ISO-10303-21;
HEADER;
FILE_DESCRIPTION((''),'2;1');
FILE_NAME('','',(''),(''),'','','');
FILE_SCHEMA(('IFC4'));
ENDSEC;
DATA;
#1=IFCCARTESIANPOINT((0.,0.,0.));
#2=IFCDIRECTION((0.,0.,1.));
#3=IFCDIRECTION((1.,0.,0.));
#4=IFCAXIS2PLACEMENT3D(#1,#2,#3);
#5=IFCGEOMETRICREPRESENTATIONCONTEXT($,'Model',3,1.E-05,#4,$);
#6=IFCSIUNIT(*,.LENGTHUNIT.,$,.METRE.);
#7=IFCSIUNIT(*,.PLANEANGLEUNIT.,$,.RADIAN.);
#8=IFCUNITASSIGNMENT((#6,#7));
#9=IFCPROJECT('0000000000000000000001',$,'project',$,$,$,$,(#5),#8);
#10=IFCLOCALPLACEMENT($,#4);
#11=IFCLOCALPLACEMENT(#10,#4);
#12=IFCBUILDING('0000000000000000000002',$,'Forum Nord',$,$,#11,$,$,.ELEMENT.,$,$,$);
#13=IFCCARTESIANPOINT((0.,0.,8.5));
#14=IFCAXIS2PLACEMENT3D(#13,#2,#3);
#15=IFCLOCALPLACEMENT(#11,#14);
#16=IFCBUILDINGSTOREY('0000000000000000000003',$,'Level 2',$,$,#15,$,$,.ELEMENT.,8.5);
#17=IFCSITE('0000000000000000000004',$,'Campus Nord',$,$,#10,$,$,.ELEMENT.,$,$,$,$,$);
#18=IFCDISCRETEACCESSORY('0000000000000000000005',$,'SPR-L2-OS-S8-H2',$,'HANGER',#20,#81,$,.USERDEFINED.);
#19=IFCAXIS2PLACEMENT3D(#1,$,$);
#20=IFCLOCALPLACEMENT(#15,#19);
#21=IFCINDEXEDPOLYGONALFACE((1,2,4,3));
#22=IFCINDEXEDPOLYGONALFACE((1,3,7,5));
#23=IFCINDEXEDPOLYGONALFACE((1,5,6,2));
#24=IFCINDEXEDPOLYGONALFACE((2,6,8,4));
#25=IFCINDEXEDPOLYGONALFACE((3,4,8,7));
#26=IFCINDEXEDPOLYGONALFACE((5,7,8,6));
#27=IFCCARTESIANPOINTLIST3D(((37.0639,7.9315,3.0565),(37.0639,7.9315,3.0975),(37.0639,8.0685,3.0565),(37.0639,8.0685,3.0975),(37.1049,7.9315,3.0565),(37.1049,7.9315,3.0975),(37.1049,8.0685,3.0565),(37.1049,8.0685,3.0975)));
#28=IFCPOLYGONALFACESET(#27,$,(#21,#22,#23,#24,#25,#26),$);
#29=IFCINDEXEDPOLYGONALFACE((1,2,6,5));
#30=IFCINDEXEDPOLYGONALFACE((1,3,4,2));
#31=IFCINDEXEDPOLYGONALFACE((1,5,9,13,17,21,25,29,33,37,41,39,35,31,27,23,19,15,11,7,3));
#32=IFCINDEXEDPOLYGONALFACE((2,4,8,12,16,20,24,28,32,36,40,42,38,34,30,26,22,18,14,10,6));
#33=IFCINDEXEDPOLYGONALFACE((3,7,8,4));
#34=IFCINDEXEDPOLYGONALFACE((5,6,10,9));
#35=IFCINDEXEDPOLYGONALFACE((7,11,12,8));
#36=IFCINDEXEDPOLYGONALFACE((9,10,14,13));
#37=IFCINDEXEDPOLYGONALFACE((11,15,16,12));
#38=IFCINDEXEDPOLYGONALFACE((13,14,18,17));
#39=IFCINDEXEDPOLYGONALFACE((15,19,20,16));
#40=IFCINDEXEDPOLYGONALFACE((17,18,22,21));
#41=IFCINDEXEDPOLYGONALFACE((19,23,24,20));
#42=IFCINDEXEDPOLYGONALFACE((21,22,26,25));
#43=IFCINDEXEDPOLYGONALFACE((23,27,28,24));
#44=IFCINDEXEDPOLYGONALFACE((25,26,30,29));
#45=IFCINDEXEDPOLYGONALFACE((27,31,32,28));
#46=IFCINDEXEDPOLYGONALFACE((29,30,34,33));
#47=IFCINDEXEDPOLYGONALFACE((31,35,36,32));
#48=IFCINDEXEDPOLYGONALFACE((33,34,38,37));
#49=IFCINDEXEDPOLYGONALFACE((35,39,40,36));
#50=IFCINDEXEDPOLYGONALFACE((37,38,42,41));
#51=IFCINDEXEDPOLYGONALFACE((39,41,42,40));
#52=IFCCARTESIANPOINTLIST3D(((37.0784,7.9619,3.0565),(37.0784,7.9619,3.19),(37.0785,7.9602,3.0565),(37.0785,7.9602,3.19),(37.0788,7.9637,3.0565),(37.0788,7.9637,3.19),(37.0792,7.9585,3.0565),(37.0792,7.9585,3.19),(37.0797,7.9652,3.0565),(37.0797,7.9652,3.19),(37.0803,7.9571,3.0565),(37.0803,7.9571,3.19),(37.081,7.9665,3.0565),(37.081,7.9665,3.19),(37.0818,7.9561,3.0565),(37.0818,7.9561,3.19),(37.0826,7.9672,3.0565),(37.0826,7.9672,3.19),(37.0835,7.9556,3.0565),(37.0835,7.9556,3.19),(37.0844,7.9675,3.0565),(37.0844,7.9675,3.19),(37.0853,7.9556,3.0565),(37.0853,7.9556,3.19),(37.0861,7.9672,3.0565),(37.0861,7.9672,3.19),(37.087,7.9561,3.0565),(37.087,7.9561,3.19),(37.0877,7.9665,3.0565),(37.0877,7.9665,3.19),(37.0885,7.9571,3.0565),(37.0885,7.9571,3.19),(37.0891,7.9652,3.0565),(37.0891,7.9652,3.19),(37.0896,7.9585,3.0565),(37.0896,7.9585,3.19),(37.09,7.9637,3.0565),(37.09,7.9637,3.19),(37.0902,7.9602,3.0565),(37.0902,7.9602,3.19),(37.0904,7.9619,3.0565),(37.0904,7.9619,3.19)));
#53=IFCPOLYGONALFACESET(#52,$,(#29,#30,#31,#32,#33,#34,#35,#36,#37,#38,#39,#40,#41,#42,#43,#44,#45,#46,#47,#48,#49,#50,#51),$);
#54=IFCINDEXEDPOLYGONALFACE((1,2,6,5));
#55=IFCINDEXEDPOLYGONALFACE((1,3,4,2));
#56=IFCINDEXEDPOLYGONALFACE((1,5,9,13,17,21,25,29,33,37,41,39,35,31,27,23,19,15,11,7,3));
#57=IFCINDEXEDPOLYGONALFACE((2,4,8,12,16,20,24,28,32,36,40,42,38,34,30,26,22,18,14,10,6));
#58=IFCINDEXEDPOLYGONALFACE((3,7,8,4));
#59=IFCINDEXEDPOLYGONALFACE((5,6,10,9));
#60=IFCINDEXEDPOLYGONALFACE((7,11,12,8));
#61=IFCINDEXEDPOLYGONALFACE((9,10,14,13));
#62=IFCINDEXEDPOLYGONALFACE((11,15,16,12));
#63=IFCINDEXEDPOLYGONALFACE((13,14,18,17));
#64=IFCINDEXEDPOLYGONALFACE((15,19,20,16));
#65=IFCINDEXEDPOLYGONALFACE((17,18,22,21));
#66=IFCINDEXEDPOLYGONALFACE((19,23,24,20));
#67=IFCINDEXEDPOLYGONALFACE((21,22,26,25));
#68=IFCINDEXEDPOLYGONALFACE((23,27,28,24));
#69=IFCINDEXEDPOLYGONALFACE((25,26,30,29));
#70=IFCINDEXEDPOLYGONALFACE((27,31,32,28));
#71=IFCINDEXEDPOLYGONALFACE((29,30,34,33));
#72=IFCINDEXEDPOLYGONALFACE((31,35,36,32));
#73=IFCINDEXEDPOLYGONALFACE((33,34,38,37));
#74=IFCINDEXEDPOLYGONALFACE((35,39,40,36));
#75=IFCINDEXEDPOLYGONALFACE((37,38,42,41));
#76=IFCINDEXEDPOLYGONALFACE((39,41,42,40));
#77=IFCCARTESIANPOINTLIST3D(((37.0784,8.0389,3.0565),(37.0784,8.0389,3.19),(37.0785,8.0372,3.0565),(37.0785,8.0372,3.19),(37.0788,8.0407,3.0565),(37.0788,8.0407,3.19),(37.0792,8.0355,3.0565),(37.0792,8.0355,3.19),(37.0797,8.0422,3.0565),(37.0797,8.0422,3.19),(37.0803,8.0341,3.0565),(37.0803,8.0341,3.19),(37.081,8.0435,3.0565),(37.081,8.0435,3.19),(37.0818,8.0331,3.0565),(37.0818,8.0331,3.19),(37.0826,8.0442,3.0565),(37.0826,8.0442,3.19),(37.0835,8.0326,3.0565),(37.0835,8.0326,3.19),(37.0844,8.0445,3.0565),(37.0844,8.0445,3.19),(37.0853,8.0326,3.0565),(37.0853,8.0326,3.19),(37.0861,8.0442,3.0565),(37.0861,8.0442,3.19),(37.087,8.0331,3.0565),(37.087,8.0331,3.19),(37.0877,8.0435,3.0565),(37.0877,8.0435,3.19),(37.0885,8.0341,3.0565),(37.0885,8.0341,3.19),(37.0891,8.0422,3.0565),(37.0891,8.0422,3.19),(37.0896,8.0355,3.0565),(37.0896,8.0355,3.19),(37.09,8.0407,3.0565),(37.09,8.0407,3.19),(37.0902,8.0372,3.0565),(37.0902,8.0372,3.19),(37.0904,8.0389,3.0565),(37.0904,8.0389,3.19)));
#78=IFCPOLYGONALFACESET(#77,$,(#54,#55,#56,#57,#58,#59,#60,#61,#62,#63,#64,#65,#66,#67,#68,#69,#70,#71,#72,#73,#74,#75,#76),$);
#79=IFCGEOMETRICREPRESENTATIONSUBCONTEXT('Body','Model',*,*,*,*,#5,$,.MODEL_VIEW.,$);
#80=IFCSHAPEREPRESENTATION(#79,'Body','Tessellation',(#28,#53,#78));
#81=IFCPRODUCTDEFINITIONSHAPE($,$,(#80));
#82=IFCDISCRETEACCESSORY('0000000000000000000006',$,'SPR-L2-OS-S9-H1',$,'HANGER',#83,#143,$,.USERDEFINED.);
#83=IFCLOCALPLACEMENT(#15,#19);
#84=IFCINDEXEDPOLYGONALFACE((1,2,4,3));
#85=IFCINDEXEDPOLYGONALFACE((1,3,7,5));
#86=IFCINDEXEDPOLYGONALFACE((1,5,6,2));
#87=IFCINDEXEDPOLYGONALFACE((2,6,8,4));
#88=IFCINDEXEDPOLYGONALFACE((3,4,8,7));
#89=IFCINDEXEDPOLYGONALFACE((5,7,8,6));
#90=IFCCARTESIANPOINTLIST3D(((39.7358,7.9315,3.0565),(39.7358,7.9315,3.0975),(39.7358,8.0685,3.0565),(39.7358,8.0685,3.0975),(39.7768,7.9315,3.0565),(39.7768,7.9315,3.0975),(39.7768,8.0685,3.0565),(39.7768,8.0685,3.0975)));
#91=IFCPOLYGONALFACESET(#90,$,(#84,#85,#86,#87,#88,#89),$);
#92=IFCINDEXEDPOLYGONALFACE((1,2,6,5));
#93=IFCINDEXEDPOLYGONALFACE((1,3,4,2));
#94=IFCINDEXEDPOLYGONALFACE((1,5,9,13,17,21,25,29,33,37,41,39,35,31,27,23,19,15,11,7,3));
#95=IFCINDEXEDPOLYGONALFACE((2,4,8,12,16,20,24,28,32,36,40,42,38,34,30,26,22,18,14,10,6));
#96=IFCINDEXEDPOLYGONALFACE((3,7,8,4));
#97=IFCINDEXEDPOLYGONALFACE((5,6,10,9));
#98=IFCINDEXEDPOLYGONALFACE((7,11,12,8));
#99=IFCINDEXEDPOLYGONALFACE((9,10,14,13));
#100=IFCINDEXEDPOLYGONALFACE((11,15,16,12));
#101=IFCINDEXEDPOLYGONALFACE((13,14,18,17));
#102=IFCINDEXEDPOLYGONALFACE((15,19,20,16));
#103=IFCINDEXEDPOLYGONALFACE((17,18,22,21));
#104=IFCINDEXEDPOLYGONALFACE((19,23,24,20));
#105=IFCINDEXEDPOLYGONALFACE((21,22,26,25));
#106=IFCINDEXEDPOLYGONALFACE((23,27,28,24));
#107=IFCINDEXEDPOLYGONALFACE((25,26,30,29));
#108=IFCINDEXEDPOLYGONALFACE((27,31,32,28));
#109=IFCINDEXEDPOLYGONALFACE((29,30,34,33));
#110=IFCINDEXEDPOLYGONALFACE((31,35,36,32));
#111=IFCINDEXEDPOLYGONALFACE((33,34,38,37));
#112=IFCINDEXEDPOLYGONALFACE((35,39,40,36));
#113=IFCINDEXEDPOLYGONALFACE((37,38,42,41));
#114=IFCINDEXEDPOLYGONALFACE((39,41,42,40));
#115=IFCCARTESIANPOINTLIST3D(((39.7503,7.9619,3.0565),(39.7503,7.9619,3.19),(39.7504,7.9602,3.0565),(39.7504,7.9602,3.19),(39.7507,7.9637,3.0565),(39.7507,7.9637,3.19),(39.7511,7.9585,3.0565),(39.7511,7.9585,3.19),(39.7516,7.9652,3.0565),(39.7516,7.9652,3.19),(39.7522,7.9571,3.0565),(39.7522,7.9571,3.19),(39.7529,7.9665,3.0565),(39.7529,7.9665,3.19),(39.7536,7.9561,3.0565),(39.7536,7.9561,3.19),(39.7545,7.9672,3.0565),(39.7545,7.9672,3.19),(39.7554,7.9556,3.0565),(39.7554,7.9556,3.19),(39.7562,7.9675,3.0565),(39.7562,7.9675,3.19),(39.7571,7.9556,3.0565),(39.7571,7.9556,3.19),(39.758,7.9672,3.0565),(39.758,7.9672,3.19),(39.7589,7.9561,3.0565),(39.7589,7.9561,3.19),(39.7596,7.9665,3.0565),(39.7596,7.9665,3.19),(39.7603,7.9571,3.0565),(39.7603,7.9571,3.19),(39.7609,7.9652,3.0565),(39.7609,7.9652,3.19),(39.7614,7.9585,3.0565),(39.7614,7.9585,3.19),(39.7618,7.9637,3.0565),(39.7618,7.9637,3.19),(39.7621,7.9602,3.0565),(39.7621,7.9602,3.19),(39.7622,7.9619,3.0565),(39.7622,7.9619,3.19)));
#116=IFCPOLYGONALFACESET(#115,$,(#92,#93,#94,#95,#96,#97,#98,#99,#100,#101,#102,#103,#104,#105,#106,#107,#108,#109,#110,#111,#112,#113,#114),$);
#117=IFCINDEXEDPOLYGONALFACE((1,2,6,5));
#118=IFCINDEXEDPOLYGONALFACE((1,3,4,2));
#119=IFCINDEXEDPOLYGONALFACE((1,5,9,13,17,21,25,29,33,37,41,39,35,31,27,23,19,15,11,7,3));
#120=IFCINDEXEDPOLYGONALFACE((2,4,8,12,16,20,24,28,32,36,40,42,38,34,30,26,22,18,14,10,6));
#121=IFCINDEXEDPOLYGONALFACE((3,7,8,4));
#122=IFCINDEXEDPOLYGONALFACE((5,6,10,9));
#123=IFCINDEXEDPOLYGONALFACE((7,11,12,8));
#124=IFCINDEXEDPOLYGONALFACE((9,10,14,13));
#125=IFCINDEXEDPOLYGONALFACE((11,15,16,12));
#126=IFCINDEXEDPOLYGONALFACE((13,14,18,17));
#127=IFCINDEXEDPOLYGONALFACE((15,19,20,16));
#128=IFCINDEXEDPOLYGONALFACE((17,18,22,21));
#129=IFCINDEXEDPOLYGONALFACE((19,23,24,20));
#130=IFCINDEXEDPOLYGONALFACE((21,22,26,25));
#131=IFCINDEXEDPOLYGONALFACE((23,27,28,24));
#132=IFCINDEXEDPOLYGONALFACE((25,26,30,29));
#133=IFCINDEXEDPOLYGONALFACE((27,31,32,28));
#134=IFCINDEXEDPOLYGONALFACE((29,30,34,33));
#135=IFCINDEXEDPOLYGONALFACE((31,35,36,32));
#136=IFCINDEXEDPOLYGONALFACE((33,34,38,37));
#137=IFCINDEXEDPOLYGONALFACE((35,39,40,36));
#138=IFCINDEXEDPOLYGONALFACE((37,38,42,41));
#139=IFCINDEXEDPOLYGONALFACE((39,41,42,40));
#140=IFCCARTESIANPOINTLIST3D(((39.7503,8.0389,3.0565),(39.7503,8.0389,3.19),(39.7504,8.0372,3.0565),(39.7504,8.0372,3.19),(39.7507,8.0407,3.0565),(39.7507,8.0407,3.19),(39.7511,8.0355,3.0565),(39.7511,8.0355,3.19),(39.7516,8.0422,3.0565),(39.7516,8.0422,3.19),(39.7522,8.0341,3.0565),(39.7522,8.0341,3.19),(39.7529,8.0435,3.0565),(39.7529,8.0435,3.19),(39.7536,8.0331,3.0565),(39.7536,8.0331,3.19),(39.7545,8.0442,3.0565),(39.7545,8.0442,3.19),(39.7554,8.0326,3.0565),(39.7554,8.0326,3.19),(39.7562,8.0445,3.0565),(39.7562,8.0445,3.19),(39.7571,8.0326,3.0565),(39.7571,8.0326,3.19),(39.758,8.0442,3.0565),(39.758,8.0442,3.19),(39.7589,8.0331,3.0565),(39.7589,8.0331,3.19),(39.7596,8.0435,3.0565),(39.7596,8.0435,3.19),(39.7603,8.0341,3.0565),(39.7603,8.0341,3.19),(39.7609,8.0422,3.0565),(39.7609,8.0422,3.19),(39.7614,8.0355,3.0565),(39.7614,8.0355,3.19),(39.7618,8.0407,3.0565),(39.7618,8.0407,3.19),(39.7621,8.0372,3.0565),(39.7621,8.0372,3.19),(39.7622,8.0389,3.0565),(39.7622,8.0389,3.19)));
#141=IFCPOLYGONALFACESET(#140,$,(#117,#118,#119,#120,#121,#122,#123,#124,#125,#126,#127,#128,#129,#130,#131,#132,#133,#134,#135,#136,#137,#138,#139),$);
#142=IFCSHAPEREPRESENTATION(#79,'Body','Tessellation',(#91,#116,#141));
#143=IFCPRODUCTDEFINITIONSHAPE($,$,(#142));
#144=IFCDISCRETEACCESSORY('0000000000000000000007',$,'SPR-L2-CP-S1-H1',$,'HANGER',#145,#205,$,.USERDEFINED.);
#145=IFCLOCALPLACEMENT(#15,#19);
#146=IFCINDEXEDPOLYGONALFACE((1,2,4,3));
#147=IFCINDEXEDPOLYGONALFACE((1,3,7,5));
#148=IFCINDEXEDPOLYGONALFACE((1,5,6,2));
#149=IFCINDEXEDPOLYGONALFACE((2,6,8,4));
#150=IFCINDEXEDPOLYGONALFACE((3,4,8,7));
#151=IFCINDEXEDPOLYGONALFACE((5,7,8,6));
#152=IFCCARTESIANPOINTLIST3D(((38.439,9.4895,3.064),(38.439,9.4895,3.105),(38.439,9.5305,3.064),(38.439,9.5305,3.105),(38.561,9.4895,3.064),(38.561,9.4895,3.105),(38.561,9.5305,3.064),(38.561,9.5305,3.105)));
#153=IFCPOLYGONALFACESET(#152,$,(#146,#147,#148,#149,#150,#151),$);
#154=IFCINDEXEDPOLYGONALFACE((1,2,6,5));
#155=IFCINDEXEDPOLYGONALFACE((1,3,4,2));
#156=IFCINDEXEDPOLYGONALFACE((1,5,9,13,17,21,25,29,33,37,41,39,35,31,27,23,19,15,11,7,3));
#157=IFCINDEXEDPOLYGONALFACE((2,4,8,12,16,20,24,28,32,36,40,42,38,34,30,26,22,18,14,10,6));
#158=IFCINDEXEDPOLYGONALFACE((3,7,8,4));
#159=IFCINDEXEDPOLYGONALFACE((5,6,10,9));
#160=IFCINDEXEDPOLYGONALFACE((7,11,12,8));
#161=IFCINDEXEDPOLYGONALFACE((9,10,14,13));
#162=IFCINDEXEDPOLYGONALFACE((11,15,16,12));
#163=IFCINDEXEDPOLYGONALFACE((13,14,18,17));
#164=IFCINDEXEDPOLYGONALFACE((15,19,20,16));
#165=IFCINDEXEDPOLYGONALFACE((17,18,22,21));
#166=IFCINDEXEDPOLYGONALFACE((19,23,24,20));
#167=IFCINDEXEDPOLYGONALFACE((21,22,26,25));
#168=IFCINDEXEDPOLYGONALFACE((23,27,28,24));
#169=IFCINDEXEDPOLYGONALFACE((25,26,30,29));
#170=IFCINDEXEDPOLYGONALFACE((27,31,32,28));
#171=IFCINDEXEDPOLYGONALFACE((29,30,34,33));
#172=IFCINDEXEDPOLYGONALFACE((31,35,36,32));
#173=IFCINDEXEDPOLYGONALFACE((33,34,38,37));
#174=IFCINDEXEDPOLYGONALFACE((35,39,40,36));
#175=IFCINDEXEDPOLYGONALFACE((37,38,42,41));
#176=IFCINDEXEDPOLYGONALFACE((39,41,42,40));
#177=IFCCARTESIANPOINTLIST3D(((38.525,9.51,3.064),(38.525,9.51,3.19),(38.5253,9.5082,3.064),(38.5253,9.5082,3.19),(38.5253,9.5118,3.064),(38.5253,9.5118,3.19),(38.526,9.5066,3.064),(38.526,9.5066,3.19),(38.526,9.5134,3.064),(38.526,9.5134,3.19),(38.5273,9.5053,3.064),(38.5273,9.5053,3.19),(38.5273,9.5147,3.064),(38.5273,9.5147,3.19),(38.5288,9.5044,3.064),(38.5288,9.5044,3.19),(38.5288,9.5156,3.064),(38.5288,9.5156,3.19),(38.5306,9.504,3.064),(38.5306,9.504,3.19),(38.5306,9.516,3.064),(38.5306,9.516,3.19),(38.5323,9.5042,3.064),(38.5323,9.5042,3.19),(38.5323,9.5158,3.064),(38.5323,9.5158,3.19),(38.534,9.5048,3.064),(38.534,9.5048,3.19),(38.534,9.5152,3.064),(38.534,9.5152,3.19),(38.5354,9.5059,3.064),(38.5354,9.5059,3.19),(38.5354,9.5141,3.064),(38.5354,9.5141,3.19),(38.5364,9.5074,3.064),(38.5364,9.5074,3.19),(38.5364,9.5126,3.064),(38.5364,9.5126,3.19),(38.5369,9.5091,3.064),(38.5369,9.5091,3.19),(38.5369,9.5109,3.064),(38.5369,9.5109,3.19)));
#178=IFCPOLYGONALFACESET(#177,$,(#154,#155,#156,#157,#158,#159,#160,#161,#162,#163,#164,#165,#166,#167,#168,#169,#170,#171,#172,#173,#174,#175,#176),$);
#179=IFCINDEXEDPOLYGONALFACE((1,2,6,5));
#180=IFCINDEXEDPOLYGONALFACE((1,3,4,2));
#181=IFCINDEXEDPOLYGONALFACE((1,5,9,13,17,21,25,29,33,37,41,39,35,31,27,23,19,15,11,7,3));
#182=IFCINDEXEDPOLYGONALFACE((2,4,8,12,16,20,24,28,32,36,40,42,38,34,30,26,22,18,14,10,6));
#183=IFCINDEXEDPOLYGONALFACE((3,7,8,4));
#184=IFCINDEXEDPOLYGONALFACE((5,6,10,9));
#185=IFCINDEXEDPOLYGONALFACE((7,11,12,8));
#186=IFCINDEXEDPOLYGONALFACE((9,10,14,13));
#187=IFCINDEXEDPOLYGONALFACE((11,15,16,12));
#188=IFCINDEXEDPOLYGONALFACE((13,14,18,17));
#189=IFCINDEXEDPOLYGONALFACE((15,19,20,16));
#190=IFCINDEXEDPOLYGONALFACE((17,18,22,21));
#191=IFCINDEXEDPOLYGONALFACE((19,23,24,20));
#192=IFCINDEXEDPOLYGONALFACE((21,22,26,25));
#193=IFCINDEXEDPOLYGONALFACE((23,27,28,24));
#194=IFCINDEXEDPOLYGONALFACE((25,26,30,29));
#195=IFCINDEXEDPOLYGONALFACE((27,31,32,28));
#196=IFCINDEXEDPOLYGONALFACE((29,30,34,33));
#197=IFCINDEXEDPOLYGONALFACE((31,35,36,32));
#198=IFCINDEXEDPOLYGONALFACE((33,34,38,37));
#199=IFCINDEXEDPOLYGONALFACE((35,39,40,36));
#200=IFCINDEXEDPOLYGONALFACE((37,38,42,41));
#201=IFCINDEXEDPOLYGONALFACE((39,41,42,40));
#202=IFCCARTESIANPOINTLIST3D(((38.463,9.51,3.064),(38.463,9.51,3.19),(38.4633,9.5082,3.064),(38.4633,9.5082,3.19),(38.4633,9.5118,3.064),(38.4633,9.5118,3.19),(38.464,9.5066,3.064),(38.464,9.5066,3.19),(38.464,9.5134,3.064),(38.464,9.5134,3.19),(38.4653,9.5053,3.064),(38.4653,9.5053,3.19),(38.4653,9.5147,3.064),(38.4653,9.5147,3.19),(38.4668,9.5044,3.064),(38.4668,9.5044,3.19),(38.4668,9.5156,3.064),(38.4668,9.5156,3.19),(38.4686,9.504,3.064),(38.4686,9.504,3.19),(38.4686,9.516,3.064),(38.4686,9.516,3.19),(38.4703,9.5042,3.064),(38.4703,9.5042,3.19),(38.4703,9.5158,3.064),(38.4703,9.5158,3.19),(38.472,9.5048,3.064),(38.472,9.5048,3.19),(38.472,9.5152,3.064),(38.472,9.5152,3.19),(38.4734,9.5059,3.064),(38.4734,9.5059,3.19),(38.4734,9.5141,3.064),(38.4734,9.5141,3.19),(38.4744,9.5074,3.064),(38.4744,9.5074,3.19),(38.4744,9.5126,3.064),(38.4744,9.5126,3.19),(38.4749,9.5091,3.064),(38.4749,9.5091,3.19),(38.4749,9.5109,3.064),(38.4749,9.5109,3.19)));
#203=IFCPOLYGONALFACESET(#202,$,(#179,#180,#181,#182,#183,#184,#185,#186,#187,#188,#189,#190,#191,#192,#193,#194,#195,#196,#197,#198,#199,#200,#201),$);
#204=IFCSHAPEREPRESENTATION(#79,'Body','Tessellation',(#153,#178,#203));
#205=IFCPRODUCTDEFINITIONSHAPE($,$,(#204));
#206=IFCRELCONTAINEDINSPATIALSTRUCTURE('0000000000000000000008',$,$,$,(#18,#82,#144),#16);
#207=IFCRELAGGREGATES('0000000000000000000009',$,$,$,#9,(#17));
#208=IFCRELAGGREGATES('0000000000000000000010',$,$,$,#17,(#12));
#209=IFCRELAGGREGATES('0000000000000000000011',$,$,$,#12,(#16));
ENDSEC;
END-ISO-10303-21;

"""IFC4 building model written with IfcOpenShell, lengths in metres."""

from ifc_helpers import new_model, si_unit, frame, frame_2d, origin_with_axes, origin_2d_with_axis, place, context, subcontext, project, spatial, rectangle, circle, extrude, element, save


model = new_model("IFC4")

# Units and contexts
model_context = context("Model", 3, precision=1e-05, world=origin_with_axes())
body_context = subcontext(model_context, "Body", "Model", "MODEL_VIEW")
ifc_project = project(units=[si_unit("LENGTHUNIT", "METRE"), si_unit("PLANEANGLEUNIT", "RADIAN")], contexts=[model_context])

# Site, building, storey
site_placement = place(None, origin_with_axes())
site = spatial("IfcSite", under=ifc_project, at=site_placement, Name="Campus Nord", CompositionType="ELEMENT")
building_placement = place(site_placement, origin_with_axes())
building = spatial("IfcBuilding", under=site, at=building_placement, Name="Forum Nord", CompositionType="ELEMENT")
storey_placement = place(building_placement, frame((0.0, 0.0, 8.5), z_axis=(0.0, 0.0, 1.0), x_axis=(1.0, 0.0, 0.0)))
storey = spatial("IfcBuildingStorey", under=building, at=storey_placement, Name="Level 2", CompositionType="ELEMENT", Elevation=8.5)

# Discrete accessories
for number, where, z_axis, x_axis, name in (
    (1, (37.0844, 8.0, 3.0975), (0.0, 0.0, 1.0), (0.0, 1.0, 0.0), "SPR-L2-OS-S8-H2"),
    (2, (39.7563, 8.0, 3.0975), (0.0, 0.0, 1.0), (0.0, 1.0, 0.0), "SPR-L2-OS-S9-H1"),
):
    element("IfcDiscreteAccessory", number, at=place(storey_placement, frame(where, z_axis=z_axis, x_axis=x_axis)), inside=storey, Name=name, ObjectType="HANGER", PredefinedType="USERDEFINED", context=body_context, shape_type="SweptSolid", body=[
        extrude(rectangle(XDim=0.137, YDim=0.041, at=origin_2d_with_axis()), frame((0.0, 0.0, -0.041), z_axis=(0.0, 0.0, 1.0), x_axis=(1.0, 0.0, 0.0)), (0.0, 0.0, 1.0), 0.041),
        extrude(circle(Radius=0.006, at=frame_2d((-0.0385, 0.0), x_axis=(1.0, 0.0))), frame((0.0, 0.0, -0.041), z_axis=(0.0, 0.0, 1.0), x_axis=(1.0, 0.0, 0.0)), (0.0, 0.0, 1.0), 0.1335),
        extrude(circle(Radius=0.006, at=frame_2d((0.0385, 0.0), x_axis=(1.0, 0.0))), frame((0.0, 0.0, -0.041), z_axis=(0.0, 0.0, 1.0), x_axis=(1.0, 0.0, 0.0)), (0.0, 0.0, 1.0), 0.1335),
    ])
discrete_accessory_1_placement = place(storey_placement, frame((38.5, 9.51, 3.105), z_axis=(0.0, 0.0, 1.0), x_axis=(-1.0, 0.0, 0.0)))
element("IfcDiscreteAccessory", 3, at=discrete_accessory_1_placement, inside=storey, Name="SPR-L2-CP-S1-H1", ObjectType="HANGER", PredefinedType="USERDEFINED", context=body_context, shape_type="SweptSolid", body=[
    extrude(rectangle(XDim=0.122, YDim=0.041, at=origin_2d_with_axis()), frame((0.0, 0.0, -0.041), z_axis=(0.0, 0.0, 1.0), x_axis=(1.0, 0.0, 0.0)), (0.0, 0.0, 1.0), 0.041),
    extrude(circle(Radius=0.006, at=frame_2d((-0.031, 0.0), x_axis=(1.0, 0.0))), frame((0.0, 0.0, -0.041), z_axis=(0.0, 0.0, 1.0), x_axis=(1.0, 0.0, 0.0)), (0.0, 0.0, 1.0), 0.126),
    extrude(circle(Radius=0.006, at=frame_2d((0.031, 0.0), x_axis=(1.0, 0.0))), frame((0.0, 0.0, -0.041), z_axis=(0.0, 0.0, 1.0), x_axis=(1.0, 0.0, 0.0)), (0.0, 0.0, 1.0), 0.126),
])

save(model, "model.ifc")
